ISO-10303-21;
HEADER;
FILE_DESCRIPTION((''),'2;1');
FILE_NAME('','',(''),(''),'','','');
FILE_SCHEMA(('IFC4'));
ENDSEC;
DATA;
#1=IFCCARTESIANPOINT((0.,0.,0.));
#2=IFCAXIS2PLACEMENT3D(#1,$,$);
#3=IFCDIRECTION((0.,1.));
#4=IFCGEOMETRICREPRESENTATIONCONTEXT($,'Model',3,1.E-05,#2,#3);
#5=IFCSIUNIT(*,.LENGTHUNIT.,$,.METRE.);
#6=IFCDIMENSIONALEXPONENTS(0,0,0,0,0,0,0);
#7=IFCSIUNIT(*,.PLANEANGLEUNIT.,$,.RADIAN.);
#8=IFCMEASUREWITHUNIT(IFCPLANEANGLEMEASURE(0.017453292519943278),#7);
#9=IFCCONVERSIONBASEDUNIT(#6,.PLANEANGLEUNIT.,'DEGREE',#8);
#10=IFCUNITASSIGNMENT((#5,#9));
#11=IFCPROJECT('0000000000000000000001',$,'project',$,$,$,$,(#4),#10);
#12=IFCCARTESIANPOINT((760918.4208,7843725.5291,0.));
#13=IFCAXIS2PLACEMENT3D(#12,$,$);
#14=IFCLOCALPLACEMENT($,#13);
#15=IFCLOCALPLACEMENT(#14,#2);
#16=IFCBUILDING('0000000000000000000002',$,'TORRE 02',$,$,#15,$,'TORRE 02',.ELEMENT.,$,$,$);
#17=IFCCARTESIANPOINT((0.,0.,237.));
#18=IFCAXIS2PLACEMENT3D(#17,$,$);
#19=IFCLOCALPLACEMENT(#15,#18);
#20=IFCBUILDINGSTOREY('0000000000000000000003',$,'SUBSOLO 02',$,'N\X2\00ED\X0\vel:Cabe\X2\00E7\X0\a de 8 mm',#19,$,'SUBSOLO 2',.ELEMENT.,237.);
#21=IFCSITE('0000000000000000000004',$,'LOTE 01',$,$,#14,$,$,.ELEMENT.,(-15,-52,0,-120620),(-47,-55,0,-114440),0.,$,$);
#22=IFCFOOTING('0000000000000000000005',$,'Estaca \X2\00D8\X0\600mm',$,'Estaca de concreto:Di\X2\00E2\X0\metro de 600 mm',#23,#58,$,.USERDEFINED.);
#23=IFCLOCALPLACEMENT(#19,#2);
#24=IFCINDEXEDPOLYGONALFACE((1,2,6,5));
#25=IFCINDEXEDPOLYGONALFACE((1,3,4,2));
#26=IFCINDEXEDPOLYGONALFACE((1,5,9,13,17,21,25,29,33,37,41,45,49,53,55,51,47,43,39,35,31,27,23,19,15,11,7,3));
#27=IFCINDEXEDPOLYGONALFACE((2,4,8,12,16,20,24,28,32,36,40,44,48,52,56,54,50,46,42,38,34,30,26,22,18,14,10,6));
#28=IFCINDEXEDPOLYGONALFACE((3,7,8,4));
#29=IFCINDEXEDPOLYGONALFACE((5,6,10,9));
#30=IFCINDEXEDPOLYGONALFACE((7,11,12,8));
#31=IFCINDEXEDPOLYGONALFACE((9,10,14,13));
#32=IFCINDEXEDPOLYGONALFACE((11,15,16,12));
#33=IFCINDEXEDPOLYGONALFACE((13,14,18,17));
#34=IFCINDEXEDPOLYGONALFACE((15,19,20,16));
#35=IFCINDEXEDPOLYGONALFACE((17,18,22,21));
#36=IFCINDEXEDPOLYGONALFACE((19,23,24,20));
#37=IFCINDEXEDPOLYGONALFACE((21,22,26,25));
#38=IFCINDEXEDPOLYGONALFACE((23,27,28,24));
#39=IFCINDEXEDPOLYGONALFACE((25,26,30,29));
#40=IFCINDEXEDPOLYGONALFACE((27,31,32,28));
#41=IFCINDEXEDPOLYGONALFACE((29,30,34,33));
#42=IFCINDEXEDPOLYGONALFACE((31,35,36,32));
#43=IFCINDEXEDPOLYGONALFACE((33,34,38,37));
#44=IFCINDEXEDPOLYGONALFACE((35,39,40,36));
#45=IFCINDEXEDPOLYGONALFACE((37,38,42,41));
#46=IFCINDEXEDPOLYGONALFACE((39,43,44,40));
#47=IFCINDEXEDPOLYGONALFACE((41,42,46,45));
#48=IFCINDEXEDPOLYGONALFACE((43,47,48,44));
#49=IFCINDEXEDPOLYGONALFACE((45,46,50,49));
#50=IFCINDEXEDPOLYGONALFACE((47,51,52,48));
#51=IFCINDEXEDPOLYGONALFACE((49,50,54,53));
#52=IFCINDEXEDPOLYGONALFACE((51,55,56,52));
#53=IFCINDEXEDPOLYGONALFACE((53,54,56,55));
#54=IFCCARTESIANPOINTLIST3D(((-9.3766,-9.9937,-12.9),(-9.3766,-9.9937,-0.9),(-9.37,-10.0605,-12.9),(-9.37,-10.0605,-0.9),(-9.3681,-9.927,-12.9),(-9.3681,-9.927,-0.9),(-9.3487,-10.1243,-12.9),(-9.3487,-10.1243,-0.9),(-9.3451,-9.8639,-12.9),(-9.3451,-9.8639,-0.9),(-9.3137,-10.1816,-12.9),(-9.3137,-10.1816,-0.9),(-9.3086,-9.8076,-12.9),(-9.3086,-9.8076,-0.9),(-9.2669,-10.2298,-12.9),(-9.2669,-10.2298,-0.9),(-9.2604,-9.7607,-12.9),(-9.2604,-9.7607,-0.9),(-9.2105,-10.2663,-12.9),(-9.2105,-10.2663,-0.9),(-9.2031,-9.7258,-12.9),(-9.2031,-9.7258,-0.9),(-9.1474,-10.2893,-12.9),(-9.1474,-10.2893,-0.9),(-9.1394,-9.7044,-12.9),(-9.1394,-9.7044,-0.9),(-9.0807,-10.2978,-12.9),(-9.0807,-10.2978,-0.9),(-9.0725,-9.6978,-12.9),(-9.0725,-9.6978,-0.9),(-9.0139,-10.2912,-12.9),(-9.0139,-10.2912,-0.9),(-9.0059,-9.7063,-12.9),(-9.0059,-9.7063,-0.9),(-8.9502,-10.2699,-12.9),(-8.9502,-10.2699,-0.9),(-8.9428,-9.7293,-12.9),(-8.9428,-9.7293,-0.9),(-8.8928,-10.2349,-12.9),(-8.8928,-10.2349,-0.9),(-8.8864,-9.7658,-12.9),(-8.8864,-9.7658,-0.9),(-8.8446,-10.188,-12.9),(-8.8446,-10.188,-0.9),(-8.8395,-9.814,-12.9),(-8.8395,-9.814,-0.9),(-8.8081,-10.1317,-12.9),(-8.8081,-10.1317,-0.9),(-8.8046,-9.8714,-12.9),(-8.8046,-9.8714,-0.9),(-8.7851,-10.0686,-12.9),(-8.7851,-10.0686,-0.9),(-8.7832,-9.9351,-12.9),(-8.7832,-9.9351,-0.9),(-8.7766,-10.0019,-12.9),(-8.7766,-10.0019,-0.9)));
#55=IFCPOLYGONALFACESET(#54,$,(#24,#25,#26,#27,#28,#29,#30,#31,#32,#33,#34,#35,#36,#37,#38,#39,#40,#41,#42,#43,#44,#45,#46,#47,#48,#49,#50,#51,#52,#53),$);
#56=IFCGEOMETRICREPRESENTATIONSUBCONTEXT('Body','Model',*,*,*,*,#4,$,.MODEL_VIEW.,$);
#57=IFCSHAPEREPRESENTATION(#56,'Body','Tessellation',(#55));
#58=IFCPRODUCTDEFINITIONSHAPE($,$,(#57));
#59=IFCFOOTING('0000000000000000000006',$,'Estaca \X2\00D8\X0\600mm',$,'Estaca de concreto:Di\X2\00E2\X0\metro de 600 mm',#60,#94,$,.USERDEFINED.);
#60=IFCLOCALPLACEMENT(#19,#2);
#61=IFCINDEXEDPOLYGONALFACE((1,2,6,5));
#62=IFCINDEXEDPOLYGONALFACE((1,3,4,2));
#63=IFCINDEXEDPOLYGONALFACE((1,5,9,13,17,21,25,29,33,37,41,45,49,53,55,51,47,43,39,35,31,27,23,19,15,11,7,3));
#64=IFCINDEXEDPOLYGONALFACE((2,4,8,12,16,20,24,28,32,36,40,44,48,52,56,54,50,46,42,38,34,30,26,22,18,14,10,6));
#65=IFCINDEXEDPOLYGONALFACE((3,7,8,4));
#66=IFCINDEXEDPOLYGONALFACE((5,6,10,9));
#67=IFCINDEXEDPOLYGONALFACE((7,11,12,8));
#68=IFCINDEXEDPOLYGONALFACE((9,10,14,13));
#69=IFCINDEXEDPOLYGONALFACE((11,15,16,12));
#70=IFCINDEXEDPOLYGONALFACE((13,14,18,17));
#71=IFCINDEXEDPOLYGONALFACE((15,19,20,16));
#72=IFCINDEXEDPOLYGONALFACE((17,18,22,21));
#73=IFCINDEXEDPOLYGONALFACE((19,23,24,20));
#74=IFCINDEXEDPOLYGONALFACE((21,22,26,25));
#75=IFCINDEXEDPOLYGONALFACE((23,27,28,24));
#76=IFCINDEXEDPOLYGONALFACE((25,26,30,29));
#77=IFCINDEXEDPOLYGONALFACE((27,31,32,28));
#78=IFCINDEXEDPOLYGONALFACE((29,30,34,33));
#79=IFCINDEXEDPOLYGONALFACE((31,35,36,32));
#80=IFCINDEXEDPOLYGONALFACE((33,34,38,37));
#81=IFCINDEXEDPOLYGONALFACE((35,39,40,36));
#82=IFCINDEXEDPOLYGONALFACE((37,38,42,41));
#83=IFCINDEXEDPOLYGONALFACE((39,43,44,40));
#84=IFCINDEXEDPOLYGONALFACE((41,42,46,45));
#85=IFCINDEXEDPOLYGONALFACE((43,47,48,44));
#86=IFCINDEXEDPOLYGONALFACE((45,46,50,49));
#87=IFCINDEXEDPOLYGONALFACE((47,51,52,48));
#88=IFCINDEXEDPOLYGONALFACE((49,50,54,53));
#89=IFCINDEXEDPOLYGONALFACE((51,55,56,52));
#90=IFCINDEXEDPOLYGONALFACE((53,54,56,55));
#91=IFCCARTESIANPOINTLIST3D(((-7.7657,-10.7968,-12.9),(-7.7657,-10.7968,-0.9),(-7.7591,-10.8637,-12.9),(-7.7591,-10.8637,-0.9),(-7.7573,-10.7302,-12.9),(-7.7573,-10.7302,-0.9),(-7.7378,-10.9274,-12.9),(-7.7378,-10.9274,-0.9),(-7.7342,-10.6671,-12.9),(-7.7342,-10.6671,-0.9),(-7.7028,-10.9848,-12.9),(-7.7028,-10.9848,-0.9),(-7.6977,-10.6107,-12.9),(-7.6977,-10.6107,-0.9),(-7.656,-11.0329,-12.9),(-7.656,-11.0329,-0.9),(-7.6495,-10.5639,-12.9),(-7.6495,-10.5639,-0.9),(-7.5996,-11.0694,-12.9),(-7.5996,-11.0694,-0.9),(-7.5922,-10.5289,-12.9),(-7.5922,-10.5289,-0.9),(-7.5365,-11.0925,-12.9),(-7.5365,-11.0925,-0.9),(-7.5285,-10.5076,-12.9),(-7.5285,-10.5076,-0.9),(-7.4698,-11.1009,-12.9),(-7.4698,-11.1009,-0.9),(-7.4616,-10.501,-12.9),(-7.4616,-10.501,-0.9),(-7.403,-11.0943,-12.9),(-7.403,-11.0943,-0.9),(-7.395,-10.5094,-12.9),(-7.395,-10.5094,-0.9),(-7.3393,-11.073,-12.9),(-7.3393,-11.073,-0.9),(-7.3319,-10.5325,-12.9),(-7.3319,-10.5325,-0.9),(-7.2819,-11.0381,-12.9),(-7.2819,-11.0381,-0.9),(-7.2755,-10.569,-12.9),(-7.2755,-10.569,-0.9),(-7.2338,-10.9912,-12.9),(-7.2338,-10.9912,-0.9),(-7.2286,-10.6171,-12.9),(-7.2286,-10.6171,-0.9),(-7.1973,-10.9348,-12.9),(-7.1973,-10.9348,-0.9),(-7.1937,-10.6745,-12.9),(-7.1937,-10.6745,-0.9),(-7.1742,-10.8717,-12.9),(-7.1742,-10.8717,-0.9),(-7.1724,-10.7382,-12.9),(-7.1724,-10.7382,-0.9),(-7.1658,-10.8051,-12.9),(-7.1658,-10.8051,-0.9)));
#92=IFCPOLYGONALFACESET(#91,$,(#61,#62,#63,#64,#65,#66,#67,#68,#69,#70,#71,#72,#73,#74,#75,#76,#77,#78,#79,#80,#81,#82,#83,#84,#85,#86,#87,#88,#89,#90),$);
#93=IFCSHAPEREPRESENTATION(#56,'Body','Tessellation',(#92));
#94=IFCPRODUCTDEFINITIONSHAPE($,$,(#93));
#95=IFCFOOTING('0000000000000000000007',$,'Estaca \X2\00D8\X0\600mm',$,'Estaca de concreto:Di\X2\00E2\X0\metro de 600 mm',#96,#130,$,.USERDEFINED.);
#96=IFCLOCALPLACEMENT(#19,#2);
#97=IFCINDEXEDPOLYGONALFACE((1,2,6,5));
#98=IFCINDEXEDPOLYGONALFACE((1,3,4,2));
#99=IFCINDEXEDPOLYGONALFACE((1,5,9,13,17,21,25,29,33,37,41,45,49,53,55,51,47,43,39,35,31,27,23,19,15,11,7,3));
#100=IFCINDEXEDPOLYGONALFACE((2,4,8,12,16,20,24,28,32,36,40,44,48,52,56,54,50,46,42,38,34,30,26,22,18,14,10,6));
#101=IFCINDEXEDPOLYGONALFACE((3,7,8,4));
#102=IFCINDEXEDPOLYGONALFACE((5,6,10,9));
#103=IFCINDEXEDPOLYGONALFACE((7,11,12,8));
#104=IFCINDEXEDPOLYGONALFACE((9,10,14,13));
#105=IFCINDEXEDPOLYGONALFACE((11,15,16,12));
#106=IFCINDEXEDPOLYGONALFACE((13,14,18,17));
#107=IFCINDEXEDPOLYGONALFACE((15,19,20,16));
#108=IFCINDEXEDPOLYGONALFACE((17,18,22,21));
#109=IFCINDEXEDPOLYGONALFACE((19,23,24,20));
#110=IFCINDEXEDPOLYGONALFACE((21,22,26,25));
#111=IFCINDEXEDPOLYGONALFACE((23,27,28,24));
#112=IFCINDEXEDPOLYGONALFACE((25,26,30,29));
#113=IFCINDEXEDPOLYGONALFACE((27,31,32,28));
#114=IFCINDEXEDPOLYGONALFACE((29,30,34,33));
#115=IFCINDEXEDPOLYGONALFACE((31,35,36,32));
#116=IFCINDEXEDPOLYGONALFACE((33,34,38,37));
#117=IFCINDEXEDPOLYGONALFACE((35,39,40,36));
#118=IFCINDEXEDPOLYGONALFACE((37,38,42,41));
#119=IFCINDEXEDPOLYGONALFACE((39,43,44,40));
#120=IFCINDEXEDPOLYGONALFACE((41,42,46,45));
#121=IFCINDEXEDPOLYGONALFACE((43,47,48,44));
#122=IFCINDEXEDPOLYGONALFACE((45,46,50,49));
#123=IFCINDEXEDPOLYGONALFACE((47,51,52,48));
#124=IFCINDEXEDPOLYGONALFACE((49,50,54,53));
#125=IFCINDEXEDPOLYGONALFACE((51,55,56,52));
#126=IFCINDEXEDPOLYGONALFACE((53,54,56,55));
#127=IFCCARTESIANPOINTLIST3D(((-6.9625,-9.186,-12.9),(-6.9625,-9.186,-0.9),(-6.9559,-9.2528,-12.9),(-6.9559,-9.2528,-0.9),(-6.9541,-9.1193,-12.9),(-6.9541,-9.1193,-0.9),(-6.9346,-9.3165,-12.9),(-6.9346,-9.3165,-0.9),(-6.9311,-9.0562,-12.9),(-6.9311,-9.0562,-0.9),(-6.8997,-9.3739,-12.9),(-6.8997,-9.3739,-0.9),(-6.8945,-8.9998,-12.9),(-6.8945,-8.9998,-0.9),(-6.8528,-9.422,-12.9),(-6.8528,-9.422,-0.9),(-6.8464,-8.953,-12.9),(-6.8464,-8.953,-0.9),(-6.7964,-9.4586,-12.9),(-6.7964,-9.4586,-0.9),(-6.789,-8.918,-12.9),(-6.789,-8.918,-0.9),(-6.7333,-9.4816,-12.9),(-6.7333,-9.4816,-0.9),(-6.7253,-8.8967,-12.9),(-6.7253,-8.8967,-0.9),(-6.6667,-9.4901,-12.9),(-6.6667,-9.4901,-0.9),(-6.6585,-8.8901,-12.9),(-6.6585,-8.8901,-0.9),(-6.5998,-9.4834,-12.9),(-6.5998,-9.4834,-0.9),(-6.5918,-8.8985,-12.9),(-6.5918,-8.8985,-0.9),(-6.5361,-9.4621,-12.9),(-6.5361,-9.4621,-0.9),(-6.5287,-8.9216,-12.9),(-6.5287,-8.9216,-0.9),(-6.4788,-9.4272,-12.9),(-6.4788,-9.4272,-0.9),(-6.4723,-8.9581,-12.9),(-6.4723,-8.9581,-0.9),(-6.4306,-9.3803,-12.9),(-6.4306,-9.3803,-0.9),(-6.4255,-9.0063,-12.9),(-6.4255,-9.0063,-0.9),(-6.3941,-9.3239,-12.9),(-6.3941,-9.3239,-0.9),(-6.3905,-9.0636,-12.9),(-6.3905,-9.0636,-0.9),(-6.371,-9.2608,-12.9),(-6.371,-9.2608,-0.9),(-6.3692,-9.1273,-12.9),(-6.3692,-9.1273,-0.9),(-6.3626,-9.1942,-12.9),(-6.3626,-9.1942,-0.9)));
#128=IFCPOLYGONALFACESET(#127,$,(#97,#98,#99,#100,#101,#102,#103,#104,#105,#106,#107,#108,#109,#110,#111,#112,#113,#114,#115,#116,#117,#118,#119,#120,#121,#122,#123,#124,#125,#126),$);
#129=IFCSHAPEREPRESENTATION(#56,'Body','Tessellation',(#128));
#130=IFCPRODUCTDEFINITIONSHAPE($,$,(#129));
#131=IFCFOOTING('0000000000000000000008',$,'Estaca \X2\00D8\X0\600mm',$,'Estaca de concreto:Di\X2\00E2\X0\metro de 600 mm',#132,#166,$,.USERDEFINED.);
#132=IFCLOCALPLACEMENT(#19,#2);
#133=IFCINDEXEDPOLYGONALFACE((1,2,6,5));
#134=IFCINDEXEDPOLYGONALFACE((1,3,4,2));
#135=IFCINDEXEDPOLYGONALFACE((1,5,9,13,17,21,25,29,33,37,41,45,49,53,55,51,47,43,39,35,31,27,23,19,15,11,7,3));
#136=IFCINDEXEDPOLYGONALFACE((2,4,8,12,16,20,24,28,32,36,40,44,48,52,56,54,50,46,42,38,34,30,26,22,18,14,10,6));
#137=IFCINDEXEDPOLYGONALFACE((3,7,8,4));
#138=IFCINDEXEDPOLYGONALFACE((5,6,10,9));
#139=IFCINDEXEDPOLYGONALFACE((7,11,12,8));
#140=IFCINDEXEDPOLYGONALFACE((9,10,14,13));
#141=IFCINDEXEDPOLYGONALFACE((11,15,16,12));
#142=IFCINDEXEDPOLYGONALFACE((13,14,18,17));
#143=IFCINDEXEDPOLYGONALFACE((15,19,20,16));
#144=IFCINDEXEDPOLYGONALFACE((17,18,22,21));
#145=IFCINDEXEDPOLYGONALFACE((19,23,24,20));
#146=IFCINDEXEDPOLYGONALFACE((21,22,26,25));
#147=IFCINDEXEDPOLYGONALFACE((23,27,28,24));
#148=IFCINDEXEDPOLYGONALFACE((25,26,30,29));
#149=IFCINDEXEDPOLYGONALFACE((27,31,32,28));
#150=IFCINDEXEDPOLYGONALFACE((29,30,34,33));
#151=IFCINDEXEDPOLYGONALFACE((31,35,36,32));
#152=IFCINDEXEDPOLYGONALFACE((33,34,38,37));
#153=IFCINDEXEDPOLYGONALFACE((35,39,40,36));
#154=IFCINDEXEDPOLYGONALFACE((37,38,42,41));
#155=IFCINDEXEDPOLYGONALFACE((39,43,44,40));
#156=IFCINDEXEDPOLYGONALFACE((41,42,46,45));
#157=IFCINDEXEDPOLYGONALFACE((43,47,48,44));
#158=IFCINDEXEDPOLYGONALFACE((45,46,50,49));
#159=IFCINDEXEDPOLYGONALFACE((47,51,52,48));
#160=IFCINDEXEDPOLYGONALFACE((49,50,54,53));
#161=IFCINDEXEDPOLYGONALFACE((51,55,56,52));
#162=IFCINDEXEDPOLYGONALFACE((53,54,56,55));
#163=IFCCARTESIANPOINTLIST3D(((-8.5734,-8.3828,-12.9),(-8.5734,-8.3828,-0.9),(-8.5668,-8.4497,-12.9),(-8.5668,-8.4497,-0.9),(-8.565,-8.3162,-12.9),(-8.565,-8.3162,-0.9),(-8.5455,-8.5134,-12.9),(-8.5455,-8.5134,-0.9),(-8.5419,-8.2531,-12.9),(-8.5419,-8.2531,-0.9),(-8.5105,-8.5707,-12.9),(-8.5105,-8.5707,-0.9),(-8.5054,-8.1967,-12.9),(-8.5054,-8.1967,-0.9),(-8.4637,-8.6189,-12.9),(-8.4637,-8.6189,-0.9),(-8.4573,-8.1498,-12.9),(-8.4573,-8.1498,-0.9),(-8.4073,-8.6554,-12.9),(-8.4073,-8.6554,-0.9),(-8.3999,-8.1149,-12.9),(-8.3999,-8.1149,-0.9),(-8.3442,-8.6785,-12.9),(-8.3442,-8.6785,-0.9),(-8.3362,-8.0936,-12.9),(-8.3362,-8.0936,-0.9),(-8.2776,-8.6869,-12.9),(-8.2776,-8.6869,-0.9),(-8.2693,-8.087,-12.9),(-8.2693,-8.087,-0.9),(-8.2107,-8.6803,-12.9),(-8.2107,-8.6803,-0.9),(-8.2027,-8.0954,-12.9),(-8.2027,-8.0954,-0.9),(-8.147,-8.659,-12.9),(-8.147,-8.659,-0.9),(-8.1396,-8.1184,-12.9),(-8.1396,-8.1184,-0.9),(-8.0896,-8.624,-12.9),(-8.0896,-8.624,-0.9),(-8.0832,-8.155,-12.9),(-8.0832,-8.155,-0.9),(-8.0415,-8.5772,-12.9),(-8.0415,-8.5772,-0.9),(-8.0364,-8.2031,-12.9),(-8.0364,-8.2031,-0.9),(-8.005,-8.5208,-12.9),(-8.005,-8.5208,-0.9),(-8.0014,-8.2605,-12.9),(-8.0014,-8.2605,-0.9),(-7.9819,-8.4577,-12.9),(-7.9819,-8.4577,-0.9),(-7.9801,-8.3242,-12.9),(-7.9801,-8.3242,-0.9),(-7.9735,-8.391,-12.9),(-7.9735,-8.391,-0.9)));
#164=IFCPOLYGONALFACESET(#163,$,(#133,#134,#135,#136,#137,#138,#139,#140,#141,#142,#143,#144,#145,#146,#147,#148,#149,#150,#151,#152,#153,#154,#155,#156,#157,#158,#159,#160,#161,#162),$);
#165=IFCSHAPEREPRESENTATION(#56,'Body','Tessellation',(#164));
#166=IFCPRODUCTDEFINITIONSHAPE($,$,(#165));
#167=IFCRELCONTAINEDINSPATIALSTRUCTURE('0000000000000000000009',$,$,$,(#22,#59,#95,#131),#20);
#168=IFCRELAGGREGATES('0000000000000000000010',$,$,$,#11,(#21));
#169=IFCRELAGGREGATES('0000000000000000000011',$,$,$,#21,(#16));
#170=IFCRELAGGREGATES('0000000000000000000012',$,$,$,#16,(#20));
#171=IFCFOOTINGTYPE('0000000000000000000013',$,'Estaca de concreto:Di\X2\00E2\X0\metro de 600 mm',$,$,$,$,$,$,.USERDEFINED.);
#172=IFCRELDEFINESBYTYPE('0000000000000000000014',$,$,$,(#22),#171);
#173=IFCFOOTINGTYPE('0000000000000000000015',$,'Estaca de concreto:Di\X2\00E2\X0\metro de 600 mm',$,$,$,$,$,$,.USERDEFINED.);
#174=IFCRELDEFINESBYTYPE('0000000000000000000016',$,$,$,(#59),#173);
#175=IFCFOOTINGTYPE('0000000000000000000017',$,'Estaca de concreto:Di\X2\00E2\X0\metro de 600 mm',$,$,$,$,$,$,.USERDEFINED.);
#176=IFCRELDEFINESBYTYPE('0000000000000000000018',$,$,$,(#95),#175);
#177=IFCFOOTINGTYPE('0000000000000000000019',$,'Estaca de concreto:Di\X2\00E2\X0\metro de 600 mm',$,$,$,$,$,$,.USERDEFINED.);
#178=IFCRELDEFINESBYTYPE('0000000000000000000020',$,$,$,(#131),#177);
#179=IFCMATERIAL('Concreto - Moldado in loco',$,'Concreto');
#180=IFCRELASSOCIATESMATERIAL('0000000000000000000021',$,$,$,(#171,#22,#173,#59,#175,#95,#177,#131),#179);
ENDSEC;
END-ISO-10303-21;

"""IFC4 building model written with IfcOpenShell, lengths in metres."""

from ifc_helpers import new_model, entity, si_unit, converted_unit, direction, frame, origin, place, context, subcontext, project, spatial, arc, indexed_curve, outline, extrude, source, transform, mapped, material, type_object, type_shapes, element, save


model = new_model("IFC4")

# Units and contexts
model_context = context("Model", 3, precision=1e-05, world=origin(), true_north=direction((0.0, 1.0)))
body_context = subcontext(model_context, "Body", "Model", "MODEL_VIEW")
ifc_project = project(units=[si_unit("LENGTHUNIT", "METRE"), converted_unit("PLANEANGLEUNIT", "DEGREE", entity("IfcPlaneAngleMeasure", 0.017453292519943278), si_unit("PLANEANGLEUNIT", "RADIAN"), dimensions=[0, 0, 0, 0, 0, 0, 0])], contexts=[model_context])

# Site, building, storey
site_placement = place(None, frame((760918.4208, 7843725.5291, 0.0)))
site = spatial("IfcSite", under=ifc_project, at=site_placement, Name="LOTE 01", CompositionType="ELEMENT", RefLatitude=(-15, -52, 0, -120620), RefLongitude=(-47, -55, 0, -114440), RefElevation=0.0)
building_placement = place(site_placement, origin())
building = spatial("IfcBuilding", under=site, at=building_placement, Name="TORRE 02", LongName="TORRE 02", CompositionType="ELEMENT")
storey_placement = place(building_placement, frame((0.0, 0.0, 237.0)))
storey = spatial("IfcBuildingStorey", under=building, at=storey_placement, Name="SUBSOLO 02", ObjectType="Nível:Cabeça de 8 mm", LongName="SUBSOLO 2", CompositionType="ELEMENT", Elevation=237.0)

# Footings
ifc_material_1 = material(Name="Concreto - Moldado in loco", Category="Concreto")
placement = place(building_placement, frame((0.0, 0.0, 237.0)))
footing_type_1 = type_object("IfcFootingType", Name="Estaca de concreto:Diâmetro de 600 mm", PredefinedType="USERDEFINED", material=ifc_material_1)
shared_shape_1 = source(origin(), body_context, "Body", "SweptSolid", [
    extrude(outline(indexed_curve([(-0.3, 0.0), (0.0, -0.3), (0.3, 0.0), (0.0, 0.3)], segments=[arc(1, 2, 3), arc(3, 4, 1)], self_intersect=False)), frame((-9.0766, -9.9978, -12.0), z_axis=(0.0, 0.0, 1.0), x_axis=(0.894934, -0.446198, 0.0)), (0.0, 0.0, 1.0), 12.0),
])
type_shapes(footing_type_1, [shared_shape_1])
footing_1_placement = place(placement, frame((0.0, 0.0, -0.9)))
element("IfcFooting", 1, at=footing_1_placement, inside=storey, type_object=footing_type_1, material=ifc_material_1, Name="Estaca Ø600mm", ObjectType="Estaca de concreto:Diâmetro de 600 mm", PredefinedType="USERDEFINED", context=body_context, shape_type="MappedRepresentation", body=[
    mapped(shared_shape_1, transform((0.0, 0.0, 0.0), scale=1.0)),
])
footing_type_2 = type_object("IfcFootingType", Name="Estaca de concreto:Diâmetro de 600 mm", PredefinedType="USERDEFINED", material=ifc_material_1)
shared_shape_2 = source(origin(), body_context, "Body", "SweptSolid", [
    extrude(outline(indexed_curve([(-0.3, 0.0), (0.0, -0.3), (0.3, 0.0), (0.0, 0.3)], segments=[arc(1, 2, 3), arc(3, 4, 1)], self_intersect=False)), frame((-7.4657, -10.801, -12.0), z_axis=(0.0, 0.0, 1.0), x_axis=(0.894934, -0.446198, 0.0)), (0.0, 0.0, 1.0), 12.0),
])
type_shapes(footing_type_2, [shared_shape_2])
footing_2_placement = place(placement, frame((0.0, 0.0, -0.9)))
element("IfcFooting", 2, at=footing_2_placement, inside=storey, type_object=footing_type_2, material=ifc_material_1, Name="Estaca Ø600mm", ObjectType="Estaca de concreto:Diâmetro de 600 mm", PredefinedType="USERDEFINED", context=body_context, shape_type="MappedRepresentation", body=[
    mapped(shared_shape_2, transform((0.0, 0.0, 0.0), scale=1.0)),
])
footing_type_3 = type_object("IfcFootingType", Name="Estaca de concreto:Diâmetro de 600 mm", PredefinedType="USERDEFINED", material=ifc_material_1)
shared_shape_3 = source(origin(), body_context, "Body", "SweptSolid", [
    extrude(outline(indexed_curve([(-0.3, 0.0), (0.0, -0.3), (0.3, 0.0), (0.0, 0.3)], segments=[arc(1, 2, 3), arc(3, 4, 1)], self_intersect=False)), frame((-6.6626, -9.1901, -12.0), z_axis=(0.0, 0.0, 1.0), x_axis=(0.894934, -0.446198, 0.0)), (0.0, 0.0, 1.0), 12.0),
])
type_shapes(footing_type_3, [shared_shape_3])
footing_3_placement = place(placement, frame((0.0, 0.0, -0.9)))
element("IfcFooting", 3, at=footing_3_placement, inside=storey, type_object=footing_type_3, material=ifc_material_1, Name="Estaca Ø600mm", ObjectType="Estaca de concreto:Diâmetro de 600 mm", PredefinedType="USERDEFINED", context=body_context, shape_type="MappedRepresentation", body=[
    mapped(shared_shape_3, transform((0.0, 0.0, 0.0), scale=1.0)),
])
footing_type_4 = type_object("IfcFootingType", Name="Estaca de concreto:Diâmetro de 600 mm", PredefinedType="USERDEFINED", material=ifc_material_1)
shared_shape_4 = source(origin(), body_context, "Body", "SweptSolid", [
    extrude(outline(indexed_curve([(-0.3, 0.0), (0.0, -0.3), (0.3, 0.0), (0.0, 0.3)], segments=[arc(1, 2, 3), arc(3, 4, 1)], self_intersect=False)), frame((-8.2735, -8.3869, -12.0), z_axis=(0.0, 0.0, 1.0), x_axis=(0.894934, -0.446198, 0.0)), (0.0, 0.0, 1.0), 12.0),
])
type_shapes(footing_type_4, [shared_shape_4])
footing_4_placement = place(placement, frame((0.0, 0.0, -0.9)))
element("IfcFooting", 4, at=footing_4_placement, inside=storey, type_object=footing_type_4, material=ifc_material_1, Name="Estaca Ø600mm", ObjectType="Estaca de concreto:Diâmetro de 600 mm", PredefinedType="USERDEFINED", context=body_context, shape_type="MappedRepresentation", body=[
    mapped(shared_shape_4, transform((0.0, 0.0, 0.0), scale=1.0)),
])

save(model, "model.ifc")
